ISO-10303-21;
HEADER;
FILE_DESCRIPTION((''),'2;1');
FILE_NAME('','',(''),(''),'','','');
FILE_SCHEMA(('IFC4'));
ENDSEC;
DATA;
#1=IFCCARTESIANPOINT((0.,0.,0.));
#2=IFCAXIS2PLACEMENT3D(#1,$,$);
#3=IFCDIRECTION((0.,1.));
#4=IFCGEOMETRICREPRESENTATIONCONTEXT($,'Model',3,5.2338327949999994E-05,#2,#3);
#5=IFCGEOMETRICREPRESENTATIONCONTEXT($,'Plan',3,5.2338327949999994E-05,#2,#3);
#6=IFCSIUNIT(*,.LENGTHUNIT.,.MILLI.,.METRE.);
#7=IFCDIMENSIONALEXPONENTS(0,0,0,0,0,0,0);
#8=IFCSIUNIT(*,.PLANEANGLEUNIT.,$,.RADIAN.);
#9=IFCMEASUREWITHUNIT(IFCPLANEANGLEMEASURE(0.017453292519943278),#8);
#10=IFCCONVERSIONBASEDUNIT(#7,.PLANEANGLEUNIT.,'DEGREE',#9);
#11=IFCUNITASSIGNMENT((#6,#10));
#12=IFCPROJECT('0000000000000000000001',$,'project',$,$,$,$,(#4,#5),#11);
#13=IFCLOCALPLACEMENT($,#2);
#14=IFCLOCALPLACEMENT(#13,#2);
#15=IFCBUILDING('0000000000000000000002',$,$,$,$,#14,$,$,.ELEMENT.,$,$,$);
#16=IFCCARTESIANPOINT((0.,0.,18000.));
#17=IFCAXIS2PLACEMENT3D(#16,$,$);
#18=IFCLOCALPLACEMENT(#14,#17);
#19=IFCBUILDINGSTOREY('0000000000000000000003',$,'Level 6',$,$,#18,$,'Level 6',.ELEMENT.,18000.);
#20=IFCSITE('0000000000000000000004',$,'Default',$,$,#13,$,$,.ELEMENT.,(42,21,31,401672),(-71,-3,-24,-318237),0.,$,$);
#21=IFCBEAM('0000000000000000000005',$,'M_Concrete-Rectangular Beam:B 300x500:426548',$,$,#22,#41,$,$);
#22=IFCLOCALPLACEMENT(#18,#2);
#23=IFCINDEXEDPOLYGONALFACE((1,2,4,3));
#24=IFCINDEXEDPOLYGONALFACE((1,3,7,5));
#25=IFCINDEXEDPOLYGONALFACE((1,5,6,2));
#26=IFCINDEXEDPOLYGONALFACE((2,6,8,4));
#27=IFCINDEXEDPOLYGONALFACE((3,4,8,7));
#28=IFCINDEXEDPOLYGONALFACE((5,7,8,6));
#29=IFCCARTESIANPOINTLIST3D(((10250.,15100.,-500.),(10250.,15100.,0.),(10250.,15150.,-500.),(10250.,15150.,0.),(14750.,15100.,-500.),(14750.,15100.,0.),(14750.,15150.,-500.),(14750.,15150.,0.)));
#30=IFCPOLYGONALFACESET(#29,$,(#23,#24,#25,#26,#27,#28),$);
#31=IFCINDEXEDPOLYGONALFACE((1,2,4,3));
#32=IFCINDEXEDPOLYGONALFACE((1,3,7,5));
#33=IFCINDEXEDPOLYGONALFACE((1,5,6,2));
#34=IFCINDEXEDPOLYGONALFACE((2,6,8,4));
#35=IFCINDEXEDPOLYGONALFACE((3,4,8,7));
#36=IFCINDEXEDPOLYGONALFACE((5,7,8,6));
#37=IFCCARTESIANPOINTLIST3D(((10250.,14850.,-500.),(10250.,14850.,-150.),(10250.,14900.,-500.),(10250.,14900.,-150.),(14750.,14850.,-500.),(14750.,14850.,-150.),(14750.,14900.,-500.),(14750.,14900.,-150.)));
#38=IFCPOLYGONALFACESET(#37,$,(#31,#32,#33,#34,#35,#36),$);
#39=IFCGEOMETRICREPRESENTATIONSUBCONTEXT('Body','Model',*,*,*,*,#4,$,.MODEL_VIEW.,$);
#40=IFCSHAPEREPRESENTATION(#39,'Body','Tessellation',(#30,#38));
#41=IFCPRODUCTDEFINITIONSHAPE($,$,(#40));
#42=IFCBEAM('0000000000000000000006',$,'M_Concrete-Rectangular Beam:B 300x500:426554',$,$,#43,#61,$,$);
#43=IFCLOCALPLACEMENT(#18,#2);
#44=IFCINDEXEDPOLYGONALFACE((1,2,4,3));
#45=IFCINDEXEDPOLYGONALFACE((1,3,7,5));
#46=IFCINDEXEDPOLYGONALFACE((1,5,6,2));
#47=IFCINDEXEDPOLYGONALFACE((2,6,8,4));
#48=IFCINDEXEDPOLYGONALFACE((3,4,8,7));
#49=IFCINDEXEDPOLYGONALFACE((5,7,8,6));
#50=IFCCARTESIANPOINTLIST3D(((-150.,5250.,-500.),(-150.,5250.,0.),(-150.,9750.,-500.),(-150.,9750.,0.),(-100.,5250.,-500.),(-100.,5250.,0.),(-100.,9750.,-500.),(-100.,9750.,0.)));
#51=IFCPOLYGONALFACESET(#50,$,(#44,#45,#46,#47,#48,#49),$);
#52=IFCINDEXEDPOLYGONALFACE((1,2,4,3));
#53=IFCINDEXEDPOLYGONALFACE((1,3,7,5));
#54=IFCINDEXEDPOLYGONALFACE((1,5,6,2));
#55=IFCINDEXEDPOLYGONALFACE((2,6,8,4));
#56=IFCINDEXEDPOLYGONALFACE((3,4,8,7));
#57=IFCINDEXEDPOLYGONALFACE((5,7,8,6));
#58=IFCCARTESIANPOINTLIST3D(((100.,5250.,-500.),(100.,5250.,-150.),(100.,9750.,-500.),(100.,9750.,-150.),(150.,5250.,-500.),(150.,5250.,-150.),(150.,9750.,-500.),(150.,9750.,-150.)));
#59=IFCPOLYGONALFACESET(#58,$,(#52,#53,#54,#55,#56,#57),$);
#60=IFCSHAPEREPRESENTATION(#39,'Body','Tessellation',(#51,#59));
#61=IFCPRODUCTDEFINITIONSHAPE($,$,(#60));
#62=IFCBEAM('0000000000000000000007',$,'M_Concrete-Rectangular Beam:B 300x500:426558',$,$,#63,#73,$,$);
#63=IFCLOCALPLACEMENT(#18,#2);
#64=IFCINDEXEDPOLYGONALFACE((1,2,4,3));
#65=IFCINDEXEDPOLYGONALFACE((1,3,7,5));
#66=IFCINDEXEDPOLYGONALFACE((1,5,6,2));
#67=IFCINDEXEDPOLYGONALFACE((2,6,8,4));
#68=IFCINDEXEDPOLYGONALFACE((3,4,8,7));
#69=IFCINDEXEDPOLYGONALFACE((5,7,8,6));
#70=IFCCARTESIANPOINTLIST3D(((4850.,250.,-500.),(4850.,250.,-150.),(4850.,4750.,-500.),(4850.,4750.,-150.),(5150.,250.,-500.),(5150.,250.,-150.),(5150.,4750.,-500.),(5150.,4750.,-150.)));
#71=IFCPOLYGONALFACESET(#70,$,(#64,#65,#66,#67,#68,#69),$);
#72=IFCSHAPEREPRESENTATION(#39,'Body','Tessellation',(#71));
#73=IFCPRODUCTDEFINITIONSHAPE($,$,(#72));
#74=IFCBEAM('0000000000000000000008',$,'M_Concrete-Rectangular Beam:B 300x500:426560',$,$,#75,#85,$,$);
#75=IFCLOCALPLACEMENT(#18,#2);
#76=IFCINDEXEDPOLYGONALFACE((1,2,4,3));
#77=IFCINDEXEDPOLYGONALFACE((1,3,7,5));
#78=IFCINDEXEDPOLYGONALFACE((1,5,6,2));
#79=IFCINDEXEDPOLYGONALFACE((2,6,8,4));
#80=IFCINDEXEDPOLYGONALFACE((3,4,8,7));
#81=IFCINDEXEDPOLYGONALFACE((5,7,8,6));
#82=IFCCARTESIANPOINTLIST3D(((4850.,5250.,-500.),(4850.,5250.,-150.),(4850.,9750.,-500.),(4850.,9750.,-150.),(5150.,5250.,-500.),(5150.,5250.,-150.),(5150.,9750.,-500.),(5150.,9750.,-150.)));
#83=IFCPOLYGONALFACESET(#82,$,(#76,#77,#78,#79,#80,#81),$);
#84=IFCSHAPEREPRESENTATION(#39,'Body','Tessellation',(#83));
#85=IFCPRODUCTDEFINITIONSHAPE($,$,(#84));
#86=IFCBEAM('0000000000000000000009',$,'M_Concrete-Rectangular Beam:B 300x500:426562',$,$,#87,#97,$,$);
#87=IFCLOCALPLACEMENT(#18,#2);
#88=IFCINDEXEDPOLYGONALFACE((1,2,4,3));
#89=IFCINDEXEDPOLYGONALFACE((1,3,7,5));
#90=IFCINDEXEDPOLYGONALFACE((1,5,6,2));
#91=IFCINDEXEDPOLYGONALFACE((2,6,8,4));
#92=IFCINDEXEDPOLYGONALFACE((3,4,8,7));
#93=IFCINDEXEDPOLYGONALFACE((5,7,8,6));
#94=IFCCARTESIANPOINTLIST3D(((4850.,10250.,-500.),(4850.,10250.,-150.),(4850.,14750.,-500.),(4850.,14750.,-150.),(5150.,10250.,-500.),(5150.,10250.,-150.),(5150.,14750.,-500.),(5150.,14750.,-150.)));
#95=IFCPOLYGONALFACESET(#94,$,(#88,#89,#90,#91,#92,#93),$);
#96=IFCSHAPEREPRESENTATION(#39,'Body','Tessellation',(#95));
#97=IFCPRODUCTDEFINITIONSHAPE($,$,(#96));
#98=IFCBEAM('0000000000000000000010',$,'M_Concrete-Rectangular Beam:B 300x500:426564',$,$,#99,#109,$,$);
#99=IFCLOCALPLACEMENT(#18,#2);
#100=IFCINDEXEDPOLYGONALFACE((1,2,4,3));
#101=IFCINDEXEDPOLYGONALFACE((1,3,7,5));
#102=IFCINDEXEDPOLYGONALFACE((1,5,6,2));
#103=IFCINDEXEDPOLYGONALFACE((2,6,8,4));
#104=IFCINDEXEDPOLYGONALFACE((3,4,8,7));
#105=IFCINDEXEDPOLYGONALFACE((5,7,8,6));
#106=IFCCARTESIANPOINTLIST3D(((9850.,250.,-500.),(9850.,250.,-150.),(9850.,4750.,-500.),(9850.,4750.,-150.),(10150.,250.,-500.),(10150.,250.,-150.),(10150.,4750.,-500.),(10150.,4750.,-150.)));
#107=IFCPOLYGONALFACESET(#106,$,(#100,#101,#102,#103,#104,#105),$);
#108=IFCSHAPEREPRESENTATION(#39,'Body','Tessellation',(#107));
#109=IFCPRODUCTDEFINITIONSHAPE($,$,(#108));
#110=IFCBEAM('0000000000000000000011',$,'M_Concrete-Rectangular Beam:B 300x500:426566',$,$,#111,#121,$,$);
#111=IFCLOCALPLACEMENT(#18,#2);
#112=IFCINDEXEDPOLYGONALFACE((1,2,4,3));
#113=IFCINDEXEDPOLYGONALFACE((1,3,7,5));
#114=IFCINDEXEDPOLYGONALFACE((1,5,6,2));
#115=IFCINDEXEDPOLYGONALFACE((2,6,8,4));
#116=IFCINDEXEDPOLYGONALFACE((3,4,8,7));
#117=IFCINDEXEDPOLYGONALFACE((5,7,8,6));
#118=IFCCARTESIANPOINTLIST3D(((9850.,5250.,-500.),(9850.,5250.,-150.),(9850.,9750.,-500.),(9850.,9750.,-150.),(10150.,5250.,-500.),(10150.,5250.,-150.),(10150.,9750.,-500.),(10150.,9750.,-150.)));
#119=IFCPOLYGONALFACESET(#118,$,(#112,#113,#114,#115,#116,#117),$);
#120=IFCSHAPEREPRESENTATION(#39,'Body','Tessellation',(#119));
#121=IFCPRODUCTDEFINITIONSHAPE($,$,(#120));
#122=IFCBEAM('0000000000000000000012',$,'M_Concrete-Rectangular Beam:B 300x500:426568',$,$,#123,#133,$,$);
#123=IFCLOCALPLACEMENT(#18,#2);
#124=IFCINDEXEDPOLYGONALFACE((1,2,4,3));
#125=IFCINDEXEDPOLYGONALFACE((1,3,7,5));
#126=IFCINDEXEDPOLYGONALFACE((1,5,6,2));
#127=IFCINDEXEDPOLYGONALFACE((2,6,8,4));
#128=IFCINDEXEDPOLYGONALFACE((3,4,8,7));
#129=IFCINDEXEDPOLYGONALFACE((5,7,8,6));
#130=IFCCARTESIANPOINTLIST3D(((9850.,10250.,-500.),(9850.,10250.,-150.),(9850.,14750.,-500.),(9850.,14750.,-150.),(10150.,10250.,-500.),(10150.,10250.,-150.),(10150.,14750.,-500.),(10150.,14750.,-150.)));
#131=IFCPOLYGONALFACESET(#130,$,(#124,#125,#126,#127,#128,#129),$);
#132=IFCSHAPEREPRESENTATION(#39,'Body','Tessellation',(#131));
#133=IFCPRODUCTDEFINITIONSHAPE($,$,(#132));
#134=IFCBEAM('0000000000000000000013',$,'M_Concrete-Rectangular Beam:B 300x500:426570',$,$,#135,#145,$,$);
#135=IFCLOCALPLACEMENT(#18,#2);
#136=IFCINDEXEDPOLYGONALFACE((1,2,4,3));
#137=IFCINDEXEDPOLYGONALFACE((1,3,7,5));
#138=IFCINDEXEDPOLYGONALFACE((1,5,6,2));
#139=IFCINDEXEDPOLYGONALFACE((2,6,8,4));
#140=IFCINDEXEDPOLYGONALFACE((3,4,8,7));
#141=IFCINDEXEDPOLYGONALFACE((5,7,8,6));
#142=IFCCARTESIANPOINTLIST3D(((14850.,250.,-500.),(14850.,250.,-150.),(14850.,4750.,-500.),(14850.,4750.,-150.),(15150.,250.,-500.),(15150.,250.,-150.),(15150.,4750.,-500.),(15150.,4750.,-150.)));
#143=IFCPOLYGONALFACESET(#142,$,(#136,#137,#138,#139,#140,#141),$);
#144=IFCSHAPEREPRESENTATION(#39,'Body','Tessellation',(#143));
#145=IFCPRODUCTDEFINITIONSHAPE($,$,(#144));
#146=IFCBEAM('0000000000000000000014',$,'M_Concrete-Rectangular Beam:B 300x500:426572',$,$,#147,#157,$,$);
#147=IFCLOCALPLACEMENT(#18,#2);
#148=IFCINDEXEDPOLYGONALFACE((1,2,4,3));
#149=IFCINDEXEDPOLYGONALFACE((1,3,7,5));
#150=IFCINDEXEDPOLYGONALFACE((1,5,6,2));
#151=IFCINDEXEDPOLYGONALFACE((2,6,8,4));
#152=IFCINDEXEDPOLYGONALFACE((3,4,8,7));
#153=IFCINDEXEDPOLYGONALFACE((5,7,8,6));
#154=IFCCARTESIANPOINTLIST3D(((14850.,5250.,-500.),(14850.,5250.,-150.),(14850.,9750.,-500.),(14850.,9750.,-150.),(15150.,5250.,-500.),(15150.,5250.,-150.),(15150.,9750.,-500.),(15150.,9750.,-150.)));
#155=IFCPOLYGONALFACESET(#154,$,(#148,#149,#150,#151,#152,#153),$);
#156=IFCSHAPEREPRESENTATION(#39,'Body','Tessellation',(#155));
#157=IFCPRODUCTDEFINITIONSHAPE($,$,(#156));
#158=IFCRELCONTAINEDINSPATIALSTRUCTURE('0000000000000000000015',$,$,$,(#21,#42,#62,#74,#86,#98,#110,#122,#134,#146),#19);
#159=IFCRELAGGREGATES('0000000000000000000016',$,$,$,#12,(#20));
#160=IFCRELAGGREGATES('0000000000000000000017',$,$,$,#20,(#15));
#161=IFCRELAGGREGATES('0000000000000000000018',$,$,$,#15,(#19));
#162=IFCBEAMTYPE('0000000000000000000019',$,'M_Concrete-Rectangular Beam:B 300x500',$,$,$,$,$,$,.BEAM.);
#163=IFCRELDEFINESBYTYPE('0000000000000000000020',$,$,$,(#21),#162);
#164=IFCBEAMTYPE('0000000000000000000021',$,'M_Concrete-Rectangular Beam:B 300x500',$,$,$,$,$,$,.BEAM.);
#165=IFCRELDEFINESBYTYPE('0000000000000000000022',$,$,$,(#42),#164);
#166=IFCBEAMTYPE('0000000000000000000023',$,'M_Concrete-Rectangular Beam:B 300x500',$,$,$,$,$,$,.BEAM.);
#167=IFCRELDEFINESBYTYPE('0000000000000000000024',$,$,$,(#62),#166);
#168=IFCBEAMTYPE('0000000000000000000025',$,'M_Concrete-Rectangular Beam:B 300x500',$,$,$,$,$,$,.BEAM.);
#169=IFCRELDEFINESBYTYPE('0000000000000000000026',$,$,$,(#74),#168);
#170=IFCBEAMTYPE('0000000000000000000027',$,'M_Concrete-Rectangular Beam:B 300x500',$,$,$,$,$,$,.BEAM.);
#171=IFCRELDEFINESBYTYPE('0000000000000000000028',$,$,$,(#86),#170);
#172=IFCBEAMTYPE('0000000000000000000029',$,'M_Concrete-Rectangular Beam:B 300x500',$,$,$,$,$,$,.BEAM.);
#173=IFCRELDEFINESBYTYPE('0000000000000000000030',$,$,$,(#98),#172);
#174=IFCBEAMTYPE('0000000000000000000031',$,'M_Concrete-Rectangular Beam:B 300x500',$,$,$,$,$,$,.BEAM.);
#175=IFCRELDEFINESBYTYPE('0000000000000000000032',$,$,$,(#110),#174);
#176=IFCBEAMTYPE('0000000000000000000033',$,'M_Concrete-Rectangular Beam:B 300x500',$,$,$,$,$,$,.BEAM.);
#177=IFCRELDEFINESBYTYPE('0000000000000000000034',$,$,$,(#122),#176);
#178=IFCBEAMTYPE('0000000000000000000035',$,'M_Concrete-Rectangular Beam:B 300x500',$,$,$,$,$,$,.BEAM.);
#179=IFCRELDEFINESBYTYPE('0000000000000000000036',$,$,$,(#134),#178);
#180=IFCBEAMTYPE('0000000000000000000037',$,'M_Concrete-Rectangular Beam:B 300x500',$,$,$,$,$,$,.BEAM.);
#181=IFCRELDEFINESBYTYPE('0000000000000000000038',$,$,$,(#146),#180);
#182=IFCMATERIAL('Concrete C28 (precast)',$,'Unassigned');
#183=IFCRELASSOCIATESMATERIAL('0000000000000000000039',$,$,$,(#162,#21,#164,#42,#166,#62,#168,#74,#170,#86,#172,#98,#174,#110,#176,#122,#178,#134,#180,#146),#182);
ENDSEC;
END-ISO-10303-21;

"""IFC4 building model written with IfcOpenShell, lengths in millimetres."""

from ifc_helpers import new_model, entity, si_unit, converted_unit, direction, frame, origin, place, context, subcontext, project, spatial, indexed_curve, outline, extrude, source, transform, mapped, material, type_object, type_shapes, element, save


model = new_model("IFC4")

# Units and contexts
model_context = context("Model", 3, precision=5.2338327949999994e-05, world=origin(), true_north=direction((0.0, 1.0)))
plan_context = context("Plan", 3, precision=5.2338327949999994e-05, world=origin(), true_north=direction((0.0, 1.0)))
body_context = subcontext(model_context, "Body", "Model", "MODEL_VIEW")
ifc_project = project(units=[si_unit("LENGTHUNIT", "METRE", prefix="MILLI"), converted_unit("PLANEANGLEUNIT", "DEGREE", entity("IfcPlaneAngleMeasure", 0.017453292519943278), si_unit("PLANEANGLEUNIT", "RADIAN"), dimensions=[0, 0, 0, 0, 0, 0, 0])], contexts=[model_context, plan_context])

# Site, building, storey
site_placement = place(None, origin())
site = spatial("IfcSite", under=ifc_project, at=site_placement, Name="Default", CompositionType="ELEMENT", RefLatitude=(42, 21, 31, 401672), RefLongitude=(-71, -3, -24, -318237), RefElevation=0.0)
building_placement = place(site_placement, origin())
building = spatial("IfcBuilding", under=site, at=building_placement, CompositionType="ELEMENT")
storey_placement = place(building_placement, frame((0.0, 0.0, 18000.0)))
storey = spatial("IfcBuildingStorey", under=building, at=storey_placement, Name="Level 6", LongName="Level 6", CompositionType="ELEMENT", Elevation=18000.0)

# Beams
ifc_material = material(Name="Concrete C28 (precast)", Category="Unassigned")
beam_type_1 = type_object("IfcBeamType", Name="M_Concrete-Rectangular Beam:B 300x500", PredefinedType="BEAM", material=ifc_material)
shared_shape_1 = source(origin(), body_context, "Body", "SweptSolid", [
    extrude(outline(indexed_curve([(-250.0, -25.0), (250.0, -25.0), (250.0, 25.0), (-250.0, 25.0), (-250.0, -25.0)], self_intersect=False)), frame((10250.0, 15125.0, 17750.0), z_axis=(1.0, 0.0, 0.0), x_axis=(0.0, 0.0, -1.0)), (0.0, 0.0, 1.0), 4500.0),
    extrude(outline(indexed_curve([(-175.0, -25.0), (175.0, -25.0), (175.0, 25.0), (-175.0, 25.0), (-175.0, -25.0)], self_intersect=False)), frame((10250.0, 14875.0, 17675.0), z_axis=(1.0, 0.0, 0.0), x_axis=(0.0, 0.0, -1.0)), (0.0, 0.0, 1.0), 4500.0),
])
type_shapes(beam_type_1, [shared_shape_1])
beam_1_placement = place(storey_placement, frame((0.0, 0.0, -18000.0)))
element("IfcBeam", 1, at=beam_1_placement, inside=storey, type_object=beam_type_1, material=ifc_material, Name="M_Concrete-Rectangular Beam:B 300x500:426548", context=body_context, shape_type="MappedRepresentation", body=[
    mapped(shared_shape_1, transform((0.0, 0.0, 0.0), scale=1.0)),
])
beam_type_2 = type_object("IfcBeamType", Name="M_Concrete-Rectangular Beam:B 300x500", PredefinedType="BEAM", material=ifc_material)
shared_shape_2 = source(origin(), body_context, "Body", "SweptSolid", [
    extrude(outline(indexed_curve([(-25.0, -250.0), (25.0, -250.0), (25.0, 250.0), (-25.0, 250.0), (-25.0, -250.0)], self_intersect=False)), frame((-125.0, 5250.0, 17750.0), z_axis=(0.0, 1.0, 0.0), x_axis=(-1.0, 0.0, 0.0)), (0.0, 0.0, 1.0), 4500.0),
    extrude(outline(indexed_curve([(-25.0, -175.0), (25.0, -175.0), (25.0, 175.0), (-25.0, 175.0), (-25.0, -175.0)], self_intersect=False)), frame((125.0, 5250.0, 17675.0), z_axis=(0.0, 1.0, 0.0), x_axis=(-1.0, 0.0, 0.0)), (0.0, 0.0, 1.0), 4500.0),
])
type_shapes(beam_type_2, [shared_shape_2])
beam_2_placement = place(storey_placement, frame((0.0, 0.0, -18000.0)))
element("IfcBeam", 2, at=beam_2_placement, inside=storey, type_object=beam_type_2, material=ifc_material, Name="M_Concrete-Rectangular Beam:B 300x500:426554", context=body_context, shape_type="MappedRepresentation", body=[
    mapped(shared_shape_2, transform((0.0, 0.0, 0.0), scale=1.0)),
])
beam_type_3 = type_object("IfcBeamType", Name="M_Concrete-Rectangular Beam:B 300x500", PredefinedType="BEAM", material=ifc_material)
shared_shape_3 = source(origin(), body_context, "Body", "SweptSolid", [
    extrude(outline(indexed_curve([(-150.0, -175.0), (150.0, -175.0), (150.0, 175.0), (-150.0, 175.0), (-150.0, -175.0)], self_intersect=False)), frame((5000.0, 250.0, 17675.0), z_axis=(0.0, 1.0, 0.0), x_axis=(-1.0, 0.0, 0.0)), (0.0, 0.0, 1.0), 4500.0),
])
type_shapes(beam_type_3, [shared_shape_3])
beam_3_placement = place(storey_placement, frame((0.0, 0.0, -18000.0)))
element("IfcBeam", 3, at=beam_3_placement, inside=storey, type_object=beam_type_3, material=ifc_material, Name="M_Concrete-Rectangular Beam:B 300x500:426558", context=body_context, shape_type="MappedRepresentation", body=[
    mapped(shared_shape_3, transform((0.0, 0.0, 0.0), scale=1.0)),
])
beam_type_4 = type_object("IfcBeamType", Name="M_Concrete-Rectangular Beam:B 300x500", PredefinedType="BEAM", material=ifc_material)
shared_shape_4 = source(origin(), body_context, "Body", "SweptSolid", [
    extrude(outline(indexed_curve([(-150.0, -175.0), (150.0, -175.0), (150.0, 175.0), (-150.0, 175.0), (-150.0, -175.0)], self_intersect=False)), frame((5000.0, 5250.0, 17675.0), z_axis=(0.0, 1.0, 0.0), x_axis=(-1.0, 0.0, 0.0)), (0.0, 0.0, 1.0), 4500.0),
])
type_shapes(beam_type_4, [shared_shape_4])
beam_4_placement = place(storey_placement, frame((0.0, 0.0, -18000.0)))
element("IfcBeam", 4, at=beam_4_placement, inside=storey, type_object=beam_type_4, material=ifc_material, Name="M_Concrete-Rectangular Beam:B 300x500:426560", context=body_context, shape_type="MappedRepresentation", body=[
    mapped(shared_shape_4, transform((0.0, 0.0, 0.0), scale=1.0)),
])
beam_type_5 = type_object("IfcBeamType", Name="M_Concrete-Rectangular Beam:B 300x500", PredefinedType="BEAM", material=ifc_material)
shared_shape_5 = source(origin(), body_context, "Body", "SweptSolid", [
    extrude(outline(indexed_curve([(-150.0, -175.0), (150.0, -175.0), (150.0, 175.0), (-150.0, 175.0), (-150.0, -175.0)], self_intersect=False)), frame((5000.0, 10250.0, 17675.0), z_axis=(0.0, 1.0, 0.0), x_axis=(-1.0, 0.0, 0.0)), (0.0, 0.0, 1.0), 4500.0),
])
type_shapes(beam_type_5, [shared_shape_5])
beam_5_placement = place(storey_placement, frame((0.0, 0.0, -18000.0)))
element("IfcBeam", 5, at=beam_5_placement, inside=storey, type_object=beam_type_5, material=ifc_material, Name="M_Concrete-Rectangular Beam:B 300x500:426562", context=body_context, shape_type="MappedRepresentation", body=[
    mapped(shared_shape_5, transform((0.0, 0.0, 0.0), scale=1.0)),
])
beam_type_6 = type_object("IfcBeamType", Name="M_Concrete-Rectangular Beam:B 300x500", PredefinedType="BEAM", material=ifc_material)
shared_shape_6 = source(origin(), body_context, "Body", "SweptSolid", [
    extrude(outline(indexed_curve([(-150.0, -175.0), (150.0, -175.0), (150.0, 175.0), (-150.0, 175.0), (-150.0, -175.0)], self_intersect=False)), frame((10000.0, 250.0, 17675.0), z_axis=(0.0, 1.0, 0.0), x_axis=(-1.0, 0.0, 0.0)), (0.0, 0.0, 1.0), 4500.0),
])
type_shapes(beam_type_6, [shared_shape_6])
beam_6_placement = place(storey_placement, frame((0.0, 0.0, -18000.0)))
element("IfcBeam", 6, at=beam_6_placement, inside=storey, type_object=beam_type_6, material=ifc_material, Name="M_Concrete-Rectangular Beam:B 300x500:426564", context=body_context, shape_type="MappedRepresentation", body=[
    mapped(shared_shape_6, transform((0.0, 0.0, 0.0), scale=1.0)),
])
beam_type_7 = type_object("IfcBeamType", Name="M_Concrete-Rectangular Beam:B 300x500", PredefinedType="BEAM", material=ifc_material)
shared_shape_7 = source(origin(), body_context, "Body", "SweptSolid", [
    extrude(outline(indexed_curve([(-150.0, -175.0), (150.0, -175.0), (150.0, 175.0), (-150.0, 175.0), (-150.0, -175.0)], self_intersect=False)), frame((10000.0, 5250.0, 17675.0), z_axis=(0.0, 1.0, 0.0), x_axis=(-1.0, 0.0, 0.0)), (0.0, 0.0, 1.0), 4500.0),
])
type_shapes(beam_type_7, [shared_shape_7])
beam_7_placement = place(storey_placement, frame((0.0, 0.0, -18000.0)))
element("IfcBeam", 7, at=beam_7_placement, inside=storey, type_object=beam_type_7, material=ifc_material, Name="M_Concrete-Rectangular Beam:B 300x500:426566", context=body_context, shape_type="MappedRepresentation", body=[
    mapped(shared_shape_7, transform((0.0, 0.0, 0.0), scale=1.0)),
])
beam_type_8 = type_object("IfcBeamType", Name="M_Concrete-Rectangular Beam:B 300x500", PredefinedType="BEAM", material=ifc_material)
shared_shape_8 = source(origin(), body_context, "Body", "SweptSolid", [
    extrude(outline(indexed_curve([(-150.0, -175.0), (150.0, -175.0), (150.0, 175.0), (-150.0, 175.0), (-150.0, -175.0)], self_intersect=False)), frame((10000.0, 10250.0, 17675.0), z_axis=(0.0, 1.0, 0.0), x_axis=(-1.0, 0.0, 0.0)), (0.0, 0.0, 1.0), 4500.0),
])
type_shapes(beam_type_8, [shared_shape_8])
beam_8_placement = place(storey_placement, frame((0.0, 0.0, -18000.0)))
element("IfcBeam", 8, at=beam_8_placement, inside=storey, type_object=beam_type_8, material=ifc_material, Name="M_Concrete-Rectangular Beam:B 300x500:426568", context=body_context, shape_type="MappedRepresentation", body=[
    mapped(shared_shape_8, transform((0.0, 0.0, 0.0), scale=1.0)),
])
beam_type_9 = type_object("IfcBeamType", Name="M_Concrete-Rectangular Beam:B 300x500", PredefinedType="BEAM", material=ifc_material)
shared_shape_9 = source(origin(), body_context, "Body", "SweptSolid", [
    extrude(outline(indexed_curve([(-150.0, -175.0), (150.0, -175.0), (150.0, 175.0), (-150.0, 175.0), (-150.0, -175.0)], self_intersect=False)), frame((15000.0, 250.0, 17675.0), z_axis=(0.0, 1.0, 0.0), x_axis=(-1.0, 0.0, 0.0)), (0.0, 0.0, 1.0), 4500.0),
])
type_shapes(beam_type_9, [shared_shape_9])
beam_9_placement = place(storey_placement, frame((0.0, 0.0, -18000.0)))
element("IfcBeam", 9, at=beam_9_placement, inside=storey, type_object=beam_type_9, material=ifc_material, Name="M_Concrete-Rectangular Beam:B 300x500:426570", context=body_context, shape_type="MappedRepresentation", body=[
    mapped(shared_shape_9, transform((0.0, 0.0, 0.0), scale=1.0)),
])
beam_type_10 = type_object("IfcBeamType", Name="M_Concrete-Rectangular Beam:B 300x500", PredefinedType="BEAM", material=ifc_material)
shared_shape_10 = source(origin(), body_context, "Body", "SweptSolid", [
    extrude(outline(indexed_curve([(-150.0, -175.0), (150.0, -175.0), (150.0, 175.0), (-150.0, 175.0), (-150.0, -175.0)], self_intersect=False)), frame((15000.0, 5250.0, 17675.0), z_axis=(0.0, 1.0, 0.0), x_axis=(-1.0, 0.0, 0.0)), (0.0, 0.0, 1.0), 4500.0),
])
type_shapes(beam_type_10, [shared_shape_10])
beam_10_placement = place(storey_placement, frame((0.0, 0.0, -18000.0)))
element("IfcBeam", 10, at=beam_10_placement, inside=storey, type_object=beam_type_10, material=ifc_material, Name="M_Concrete-Rectangular Beam:B 300x500:426572", context=body_context, shape_type="MappedRepresentation", body=[
    mapped(shared_shape_10, transform((0.0, 0.0, 0.0), scale=1.0)),
])

save(model, "model.ifc")
